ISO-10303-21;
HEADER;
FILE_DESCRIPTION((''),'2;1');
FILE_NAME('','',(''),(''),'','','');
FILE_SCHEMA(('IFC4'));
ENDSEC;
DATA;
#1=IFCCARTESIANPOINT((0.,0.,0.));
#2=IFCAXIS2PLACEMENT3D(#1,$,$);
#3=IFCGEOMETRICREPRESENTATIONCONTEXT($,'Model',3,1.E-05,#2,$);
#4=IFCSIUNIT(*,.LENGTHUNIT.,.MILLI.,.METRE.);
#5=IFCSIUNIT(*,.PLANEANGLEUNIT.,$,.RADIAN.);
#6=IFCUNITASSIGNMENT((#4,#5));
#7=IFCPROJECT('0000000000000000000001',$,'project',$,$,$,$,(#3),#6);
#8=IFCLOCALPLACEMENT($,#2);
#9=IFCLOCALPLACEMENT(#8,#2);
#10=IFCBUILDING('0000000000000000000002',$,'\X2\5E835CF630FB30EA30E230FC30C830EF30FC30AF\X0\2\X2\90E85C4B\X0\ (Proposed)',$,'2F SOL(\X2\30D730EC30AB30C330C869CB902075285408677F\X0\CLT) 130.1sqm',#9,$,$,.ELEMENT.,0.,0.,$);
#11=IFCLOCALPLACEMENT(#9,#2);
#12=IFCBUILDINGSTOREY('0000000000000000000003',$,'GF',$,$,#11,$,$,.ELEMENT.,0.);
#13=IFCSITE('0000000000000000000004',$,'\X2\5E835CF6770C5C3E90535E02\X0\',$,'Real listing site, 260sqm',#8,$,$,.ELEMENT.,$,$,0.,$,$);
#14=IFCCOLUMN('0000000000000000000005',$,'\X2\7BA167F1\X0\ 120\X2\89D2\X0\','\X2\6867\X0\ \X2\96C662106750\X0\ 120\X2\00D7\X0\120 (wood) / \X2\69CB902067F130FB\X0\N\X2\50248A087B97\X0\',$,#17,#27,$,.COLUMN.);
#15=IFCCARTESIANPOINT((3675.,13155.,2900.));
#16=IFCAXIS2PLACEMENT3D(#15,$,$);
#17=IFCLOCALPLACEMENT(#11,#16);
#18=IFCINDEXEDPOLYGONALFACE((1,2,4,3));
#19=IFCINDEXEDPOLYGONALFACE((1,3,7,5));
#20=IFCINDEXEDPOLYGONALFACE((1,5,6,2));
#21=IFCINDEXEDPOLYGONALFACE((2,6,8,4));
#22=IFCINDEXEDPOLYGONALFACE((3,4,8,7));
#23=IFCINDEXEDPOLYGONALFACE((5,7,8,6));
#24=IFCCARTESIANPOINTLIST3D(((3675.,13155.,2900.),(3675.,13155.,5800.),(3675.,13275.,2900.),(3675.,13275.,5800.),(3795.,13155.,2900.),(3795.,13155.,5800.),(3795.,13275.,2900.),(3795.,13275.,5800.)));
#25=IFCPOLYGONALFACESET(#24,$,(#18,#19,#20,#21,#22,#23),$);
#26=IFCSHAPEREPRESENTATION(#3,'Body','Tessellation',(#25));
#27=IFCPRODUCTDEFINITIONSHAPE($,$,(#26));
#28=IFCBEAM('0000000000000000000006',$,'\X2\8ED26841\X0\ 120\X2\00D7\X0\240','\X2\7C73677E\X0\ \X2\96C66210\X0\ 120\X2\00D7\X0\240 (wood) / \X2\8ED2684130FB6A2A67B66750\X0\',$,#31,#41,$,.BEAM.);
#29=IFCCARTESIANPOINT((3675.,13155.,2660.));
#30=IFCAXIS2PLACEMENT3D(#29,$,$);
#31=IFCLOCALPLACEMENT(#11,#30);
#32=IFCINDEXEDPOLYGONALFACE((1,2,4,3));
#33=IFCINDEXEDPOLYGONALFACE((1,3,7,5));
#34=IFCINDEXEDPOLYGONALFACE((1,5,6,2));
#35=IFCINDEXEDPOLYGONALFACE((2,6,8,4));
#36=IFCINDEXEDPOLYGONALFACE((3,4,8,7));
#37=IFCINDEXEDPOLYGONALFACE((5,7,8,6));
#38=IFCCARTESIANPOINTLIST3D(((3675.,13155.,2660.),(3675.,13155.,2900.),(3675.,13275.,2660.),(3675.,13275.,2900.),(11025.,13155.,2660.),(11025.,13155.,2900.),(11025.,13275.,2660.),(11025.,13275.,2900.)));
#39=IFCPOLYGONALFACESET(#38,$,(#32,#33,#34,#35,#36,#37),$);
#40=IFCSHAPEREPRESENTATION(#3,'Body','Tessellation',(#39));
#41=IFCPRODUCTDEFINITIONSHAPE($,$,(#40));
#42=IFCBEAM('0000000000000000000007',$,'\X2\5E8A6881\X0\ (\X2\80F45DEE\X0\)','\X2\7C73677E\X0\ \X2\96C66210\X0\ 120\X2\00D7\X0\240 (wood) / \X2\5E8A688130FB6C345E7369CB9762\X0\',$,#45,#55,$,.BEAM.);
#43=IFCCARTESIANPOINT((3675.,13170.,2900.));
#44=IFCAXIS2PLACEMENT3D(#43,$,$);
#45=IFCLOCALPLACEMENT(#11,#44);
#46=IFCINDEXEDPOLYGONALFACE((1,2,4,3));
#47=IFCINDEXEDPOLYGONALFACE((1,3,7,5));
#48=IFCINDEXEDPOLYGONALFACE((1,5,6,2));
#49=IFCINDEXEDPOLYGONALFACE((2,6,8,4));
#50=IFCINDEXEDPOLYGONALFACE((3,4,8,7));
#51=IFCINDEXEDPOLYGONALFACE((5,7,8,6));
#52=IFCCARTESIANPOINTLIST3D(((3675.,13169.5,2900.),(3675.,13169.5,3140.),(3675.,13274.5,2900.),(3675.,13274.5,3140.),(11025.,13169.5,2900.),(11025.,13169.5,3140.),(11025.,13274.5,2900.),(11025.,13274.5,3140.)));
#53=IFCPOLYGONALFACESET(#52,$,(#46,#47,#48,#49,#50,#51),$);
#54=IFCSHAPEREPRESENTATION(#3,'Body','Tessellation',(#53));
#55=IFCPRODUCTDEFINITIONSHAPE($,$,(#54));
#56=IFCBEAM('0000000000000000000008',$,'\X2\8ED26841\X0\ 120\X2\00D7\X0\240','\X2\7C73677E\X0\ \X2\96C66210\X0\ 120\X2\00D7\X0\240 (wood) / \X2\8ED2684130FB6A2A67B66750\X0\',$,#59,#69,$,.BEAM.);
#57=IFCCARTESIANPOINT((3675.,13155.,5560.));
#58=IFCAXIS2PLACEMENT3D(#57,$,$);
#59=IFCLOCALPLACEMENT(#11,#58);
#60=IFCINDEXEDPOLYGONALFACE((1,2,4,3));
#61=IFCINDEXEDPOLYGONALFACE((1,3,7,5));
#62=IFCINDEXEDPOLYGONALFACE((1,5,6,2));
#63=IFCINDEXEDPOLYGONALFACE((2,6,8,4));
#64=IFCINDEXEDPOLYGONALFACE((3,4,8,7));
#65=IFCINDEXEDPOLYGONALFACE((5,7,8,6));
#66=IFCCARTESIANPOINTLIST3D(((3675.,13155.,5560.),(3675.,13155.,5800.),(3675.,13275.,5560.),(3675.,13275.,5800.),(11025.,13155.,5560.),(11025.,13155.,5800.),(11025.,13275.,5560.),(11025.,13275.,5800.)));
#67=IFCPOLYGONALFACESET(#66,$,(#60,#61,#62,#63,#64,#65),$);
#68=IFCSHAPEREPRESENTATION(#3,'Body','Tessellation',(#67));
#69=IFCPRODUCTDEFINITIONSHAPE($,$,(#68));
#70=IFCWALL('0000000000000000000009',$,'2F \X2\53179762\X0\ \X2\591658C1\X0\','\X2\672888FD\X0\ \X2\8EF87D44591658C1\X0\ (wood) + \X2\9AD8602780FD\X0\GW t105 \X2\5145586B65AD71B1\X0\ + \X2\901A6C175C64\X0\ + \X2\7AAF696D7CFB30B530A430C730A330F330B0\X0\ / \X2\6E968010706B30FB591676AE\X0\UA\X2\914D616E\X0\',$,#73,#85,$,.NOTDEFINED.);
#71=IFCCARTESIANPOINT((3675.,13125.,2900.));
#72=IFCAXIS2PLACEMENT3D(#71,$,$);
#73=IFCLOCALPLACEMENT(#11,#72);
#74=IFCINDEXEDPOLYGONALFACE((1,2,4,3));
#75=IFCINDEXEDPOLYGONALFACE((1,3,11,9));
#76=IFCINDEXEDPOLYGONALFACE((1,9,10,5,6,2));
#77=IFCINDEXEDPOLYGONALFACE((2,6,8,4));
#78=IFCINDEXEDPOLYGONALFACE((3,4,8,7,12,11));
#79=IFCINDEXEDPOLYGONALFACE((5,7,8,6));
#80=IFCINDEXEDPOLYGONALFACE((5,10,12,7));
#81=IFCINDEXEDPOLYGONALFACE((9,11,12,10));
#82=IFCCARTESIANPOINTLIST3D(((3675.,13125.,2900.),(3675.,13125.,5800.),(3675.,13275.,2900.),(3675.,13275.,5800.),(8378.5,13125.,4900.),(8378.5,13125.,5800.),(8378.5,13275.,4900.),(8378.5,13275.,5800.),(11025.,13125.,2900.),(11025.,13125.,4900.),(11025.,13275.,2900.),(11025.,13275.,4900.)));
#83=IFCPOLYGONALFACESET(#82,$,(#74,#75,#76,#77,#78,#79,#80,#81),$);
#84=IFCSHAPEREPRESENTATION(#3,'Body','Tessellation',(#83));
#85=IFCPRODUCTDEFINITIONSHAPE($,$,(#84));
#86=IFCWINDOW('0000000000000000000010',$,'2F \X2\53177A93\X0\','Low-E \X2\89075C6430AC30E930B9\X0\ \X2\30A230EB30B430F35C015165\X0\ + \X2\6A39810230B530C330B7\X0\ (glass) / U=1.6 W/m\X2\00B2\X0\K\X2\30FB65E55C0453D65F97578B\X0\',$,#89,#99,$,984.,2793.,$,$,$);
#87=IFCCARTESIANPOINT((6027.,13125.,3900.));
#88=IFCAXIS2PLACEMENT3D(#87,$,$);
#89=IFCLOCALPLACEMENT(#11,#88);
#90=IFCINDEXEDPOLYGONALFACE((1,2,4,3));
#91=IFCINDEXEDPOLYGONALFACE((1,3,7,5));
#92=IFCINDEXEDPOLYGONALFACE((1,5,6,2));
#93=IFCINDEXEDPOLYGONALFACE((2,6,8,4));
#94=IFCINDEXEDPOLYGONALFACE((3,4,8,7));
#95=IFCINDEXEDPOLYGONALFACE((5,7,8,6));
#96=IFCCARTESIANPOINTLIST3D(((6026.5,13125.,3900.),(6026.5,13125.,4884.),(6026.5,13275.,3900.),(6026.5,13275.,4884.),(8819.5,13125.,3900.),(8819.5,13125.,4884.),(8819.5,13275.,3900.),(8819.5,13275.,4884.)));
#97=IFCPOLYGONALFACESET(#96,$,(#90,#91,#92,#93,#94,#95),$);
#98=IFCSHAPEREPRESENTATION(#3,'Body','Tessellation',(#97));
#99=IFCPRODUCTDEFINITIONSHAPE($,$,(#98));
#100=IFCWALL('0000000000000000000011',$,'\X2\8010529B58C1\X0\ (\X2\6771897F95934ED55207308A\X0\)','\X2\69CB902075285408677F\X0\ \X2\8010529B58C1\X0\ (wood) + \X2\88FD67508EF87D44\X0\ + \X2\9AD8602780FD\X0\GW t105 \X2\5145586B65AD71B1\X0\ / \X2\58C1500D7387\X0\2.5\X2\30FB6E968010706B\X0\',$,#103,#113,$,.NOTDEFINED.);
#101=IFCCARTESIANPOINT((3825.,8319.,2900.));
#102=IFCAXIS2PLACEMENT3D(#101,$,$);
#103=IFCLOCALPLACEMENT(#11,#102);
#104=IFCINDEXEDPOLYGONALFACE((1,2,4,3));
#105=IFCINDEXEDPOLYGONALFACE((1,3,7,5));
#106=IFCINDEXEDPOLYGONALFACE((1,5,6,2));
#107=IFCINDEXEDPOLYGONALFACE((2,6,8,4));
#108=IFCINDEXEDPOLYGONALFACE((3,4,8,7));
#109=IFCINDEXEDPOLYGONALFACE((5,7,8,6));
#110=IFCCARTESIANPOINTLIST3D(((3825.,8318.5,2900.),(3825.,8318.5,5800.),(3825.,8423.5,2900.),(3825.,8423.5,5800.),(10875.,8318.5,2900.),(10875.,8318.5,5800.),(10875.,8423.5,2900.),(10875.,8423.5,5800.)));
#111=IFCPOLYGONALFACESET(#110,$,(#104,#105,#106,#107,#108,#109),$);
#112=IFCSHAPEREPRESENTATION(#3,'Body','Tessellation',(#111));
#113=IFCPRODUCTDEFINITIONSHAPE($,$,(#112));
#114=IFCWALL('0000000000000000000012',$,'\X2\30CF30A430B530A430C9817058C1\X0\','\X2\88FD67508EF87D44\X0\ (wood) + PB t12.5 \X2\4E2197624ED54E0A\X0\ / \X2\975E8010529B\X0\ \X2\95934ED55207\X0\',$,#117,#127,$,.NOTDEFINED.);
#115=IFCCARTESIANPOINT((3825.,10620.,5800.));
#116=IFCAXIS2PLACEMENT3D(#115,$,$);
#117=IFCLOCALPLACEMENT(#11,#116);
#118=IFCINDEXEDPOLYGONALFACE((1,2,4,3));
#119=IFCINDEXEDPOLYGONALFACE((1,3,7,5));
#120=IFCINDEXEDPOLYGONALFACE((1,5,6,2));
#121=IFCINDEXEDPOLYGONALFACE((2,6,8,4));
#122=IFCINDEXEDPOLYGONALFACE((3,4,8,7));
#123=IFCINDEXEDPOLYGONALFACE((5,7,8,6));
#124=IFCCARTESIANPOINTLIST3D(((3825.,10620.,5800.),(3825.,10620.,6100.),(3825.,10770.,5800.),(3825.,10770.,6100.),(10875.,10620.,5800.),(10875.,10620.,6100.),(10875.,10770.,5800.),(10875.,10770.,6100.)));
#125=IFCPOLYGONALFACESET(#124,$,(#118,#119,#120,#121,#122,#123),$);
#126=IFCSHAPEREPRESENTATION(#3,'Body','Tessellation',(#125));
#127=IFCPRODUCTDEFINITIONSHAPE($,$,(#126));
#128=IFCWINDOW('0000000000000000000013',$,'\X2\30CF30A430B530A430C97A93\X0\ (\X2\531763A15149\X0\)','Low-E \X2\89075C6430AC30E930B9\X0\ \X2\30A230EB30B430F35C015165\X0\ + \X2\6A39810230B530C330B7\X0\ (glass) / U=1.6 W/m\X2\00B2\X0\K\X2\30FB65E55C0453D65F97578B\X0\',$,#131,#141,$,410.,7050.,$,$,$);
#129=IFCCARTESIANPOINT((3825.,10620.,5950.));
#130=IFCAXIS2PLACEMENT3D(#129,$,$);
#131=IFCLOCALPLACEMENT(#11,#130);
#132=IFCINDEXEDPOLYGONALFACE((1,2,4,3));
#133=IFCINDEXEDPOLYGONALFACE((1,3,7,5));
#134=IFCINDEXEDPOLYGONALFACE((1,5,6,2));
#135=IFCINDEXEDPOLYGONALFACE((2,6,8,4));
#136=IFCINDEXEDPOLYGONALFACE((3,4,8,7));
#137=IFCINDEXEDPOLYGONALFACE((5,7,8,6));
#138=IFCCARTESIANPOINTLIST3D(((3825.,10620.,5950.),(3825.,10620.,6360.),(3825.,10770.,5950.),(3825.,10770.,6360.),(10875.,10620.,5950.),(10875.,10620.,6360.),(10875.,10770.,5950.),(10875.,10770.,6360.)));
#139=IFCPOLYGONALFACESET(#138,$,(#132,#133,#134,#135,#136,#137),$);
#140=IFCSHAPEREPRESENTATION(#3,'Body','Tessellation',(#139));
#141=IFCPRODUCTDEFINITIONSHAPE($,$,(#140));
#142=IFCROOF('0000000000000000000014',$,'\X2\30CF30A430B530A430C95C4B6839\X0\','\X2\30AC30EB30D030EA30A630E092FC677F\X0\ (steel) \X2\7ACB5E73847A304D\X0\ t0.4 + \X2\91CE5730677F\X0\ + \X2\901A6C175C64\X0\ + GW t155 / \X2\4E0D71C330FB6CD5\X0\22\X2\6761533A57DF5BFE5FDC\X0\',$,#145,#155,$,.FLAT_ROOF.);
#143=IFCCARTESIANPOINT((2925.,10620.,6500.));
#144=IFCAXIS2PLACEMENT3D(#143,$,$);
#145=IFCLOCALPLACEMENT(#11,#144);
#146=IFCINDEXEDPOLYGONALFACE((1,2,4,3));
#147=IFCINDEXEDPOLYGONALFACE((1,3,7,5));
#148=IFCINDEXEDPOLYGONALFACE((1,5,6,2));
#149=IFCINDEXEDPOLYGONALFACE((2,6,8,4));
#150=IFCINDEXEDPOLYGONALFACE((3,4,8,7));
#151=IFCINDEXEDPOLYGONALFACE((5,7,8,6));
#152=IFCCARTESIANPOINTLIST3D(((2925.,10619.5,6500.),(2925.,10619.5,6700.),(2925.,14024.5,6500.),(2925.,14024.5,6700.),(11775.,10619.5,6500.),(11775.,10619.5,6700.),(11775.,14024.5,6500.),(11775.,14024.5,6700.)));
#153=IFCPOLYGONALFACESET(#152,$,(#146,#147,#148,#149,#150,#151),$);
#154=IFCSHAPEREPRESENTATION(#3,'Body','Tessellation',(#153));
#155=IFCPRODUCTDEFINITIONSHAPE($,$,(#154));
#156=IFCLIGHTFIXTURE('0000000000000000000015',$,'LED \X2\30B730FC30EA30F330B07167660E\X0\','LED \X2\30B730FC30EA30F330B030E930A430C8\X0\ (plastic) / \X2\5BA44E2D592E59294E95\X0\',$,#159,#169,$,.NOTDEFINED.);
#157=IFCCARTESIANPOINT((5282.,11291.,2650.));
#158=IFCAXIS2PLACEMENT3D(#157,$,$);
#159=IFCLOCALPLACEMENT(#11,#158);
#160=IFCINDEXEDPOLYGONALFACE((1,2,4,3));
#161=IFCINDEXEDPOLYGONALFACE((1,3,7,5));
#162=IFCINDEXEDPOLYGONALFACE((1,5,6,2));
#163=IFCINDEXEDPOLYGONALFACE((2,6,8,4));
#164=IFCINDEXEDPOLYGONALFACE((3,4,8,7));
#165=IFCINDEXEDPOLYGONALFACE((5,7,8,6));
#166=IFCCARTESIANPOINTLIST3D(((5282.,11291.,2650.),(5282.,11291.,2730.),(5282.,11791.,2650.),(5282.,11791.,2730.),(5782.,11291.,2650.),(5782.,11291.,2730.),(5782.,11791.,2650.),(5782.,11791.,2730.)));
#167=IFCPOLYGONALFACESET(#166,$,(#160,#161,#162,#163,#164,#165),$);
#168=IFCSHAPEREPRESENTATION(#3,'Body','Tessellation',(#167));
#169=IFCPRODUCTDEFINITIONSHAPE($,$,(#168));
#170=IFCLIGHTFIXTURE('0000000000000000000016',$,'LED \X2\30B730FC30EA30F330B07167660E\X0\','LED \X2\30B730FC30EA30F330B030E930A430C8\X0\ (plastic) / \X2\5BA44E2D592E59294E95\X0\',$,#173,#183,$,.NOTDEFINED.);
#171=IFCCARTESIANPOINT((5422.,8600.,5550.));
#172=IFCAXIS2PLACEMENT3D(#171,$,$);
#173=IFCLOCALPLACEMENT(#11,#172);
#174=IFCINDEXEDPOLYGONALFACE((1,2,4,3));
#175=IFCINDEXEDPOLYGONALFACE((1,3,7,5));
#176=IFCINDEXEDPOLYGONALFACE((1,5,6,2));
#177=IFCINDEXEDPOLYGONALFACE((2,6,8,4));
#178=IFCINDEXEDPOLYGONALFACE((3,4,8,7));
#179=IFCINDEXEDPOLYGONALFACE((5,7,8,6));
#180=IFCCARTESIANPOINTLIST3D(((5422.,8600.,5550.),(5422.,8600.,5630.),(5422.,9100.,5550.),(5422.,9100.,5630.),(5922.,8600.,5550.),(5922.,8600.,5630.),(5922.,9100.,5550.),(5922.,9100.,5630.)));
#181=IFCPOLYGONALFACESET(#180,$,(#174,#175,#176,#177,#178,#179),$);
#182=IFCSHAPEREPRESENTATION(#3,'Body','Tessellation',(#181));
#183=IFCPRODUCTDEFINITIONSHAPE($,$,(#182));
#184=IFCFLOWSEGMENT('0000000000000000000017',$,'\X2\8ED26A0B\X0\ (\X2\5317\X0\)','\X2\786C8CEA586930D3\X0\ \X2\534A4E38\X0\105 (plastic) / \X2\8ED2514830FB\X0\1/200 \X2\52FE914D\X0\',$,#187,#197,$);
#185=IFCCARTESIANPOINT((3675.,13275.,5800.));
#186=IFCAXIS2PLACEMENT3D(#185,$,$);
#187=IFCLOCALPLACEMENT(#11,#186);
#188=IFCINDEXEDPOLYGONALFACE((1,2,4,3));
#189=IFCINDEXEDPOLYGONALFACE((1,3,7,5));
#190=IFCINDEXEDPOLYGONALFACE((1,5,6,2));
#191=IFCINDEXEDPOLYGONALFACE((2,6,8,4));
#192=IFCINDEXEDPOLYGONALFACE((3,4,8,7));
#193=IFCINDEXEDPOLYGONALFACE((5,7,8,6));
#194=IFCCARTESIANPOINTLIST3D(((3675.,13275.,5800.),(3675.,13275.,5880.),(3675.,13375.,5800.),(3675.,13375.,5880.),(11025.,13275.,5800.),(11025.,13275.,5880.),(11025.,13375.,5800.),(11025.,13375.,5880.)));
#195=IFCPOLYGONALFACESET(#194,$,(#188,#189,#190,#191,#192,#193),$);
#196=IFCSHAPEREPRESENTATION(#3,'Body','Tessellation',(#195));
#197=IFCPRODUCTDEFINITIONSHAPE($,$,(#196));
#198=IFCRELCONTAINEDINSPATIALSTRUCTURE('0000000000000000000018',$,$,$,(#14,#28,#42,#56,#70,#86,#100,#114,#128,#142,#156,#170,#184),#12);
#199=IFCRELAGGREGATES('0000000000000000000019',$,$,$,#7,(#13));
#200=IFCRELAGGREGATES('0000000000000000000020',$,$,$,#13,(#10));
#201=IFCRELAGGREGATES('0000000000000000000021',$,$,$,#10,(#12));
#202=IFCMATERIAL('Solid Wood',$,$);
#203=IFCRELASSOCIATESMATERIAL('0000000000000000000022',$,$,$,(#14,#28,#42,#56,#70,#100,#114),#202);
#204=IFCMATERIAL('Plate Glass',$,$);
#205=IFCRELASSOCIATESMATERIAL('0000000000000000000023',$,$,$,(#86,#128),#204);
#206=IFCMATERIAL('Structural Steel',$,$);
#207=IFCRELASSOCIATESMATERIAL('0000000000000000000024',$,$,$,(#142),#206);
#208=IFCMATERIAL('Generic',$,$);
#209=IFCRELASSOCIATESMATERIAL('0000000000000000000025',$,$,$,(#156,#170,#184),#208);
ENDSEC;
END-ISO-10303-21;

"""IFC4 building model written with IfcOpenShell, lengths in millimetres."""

from ifc_helpers import new_model, si_unit, frame, frame_2d, origin, place, context, project, spatial, rectangle, extrude, material, element, fill, save


model = new_model("IFC4")

# Units and contexts
model_context = context("Model", 3, precision=1e-05, world=origin())
ifc_project = project(units=[si_unit("LENGTHUNIT", "METRE", prefix="MILLI"), si_unit("PLANEANGLEUNIT", "RADIAN")], contexts=[model_context])

# Site, building, storey
site_placement = place(None, origin())
site = spatial("IfcSite", under=ifc_project, at=site_placement, Name="広島県尾道市", ObjectType="Real listing site, 260sqm", CompositionType="ELEMENT", RefElevation=0.0)
building_placement = place(site_placement, origin())
building = spatial("IfcBuilding", under=site, at=building_placement, Name="広島・リモートワーク2部屋 (Proposed)", ObjectType="2F SOL(プレカット構造用合板CLT) 130.1sqm", CompositionType="ELEMENT", ElevationOfRefHeight=0.0, ElevationOfTerrain=0.0)
storey_placement = place(building_placement, origin())
storey = spatial("IfcBuildingStorey", under=building, at=storey_placement, Name="GF", CompositionType="ELEMENT", Elevation=0.0)

# Column
ifc_material_1 = material(Name="Solid Wood")
column_1_placement = place(storey_placement, frame((3675.0, 13155.0, 2900.0)))
element("IfcColumn", 1, at=column_1_placement, inside=storey, material=ifc_material_1, Name="管柱 120角", Description="桧 集成材 120×120 (wood) / 構造柱・N値計算", PredefinedType="COLUMN", context=model_context, shape_type="SweptSolid", body=[
    extrude(rectangle(XDim=120.0, YDim=120.0, at=frame_2d((60.0, 60.0))), frame((3675.0, 13155.0, 2900.0)), (0.0, 0.0, 1.0), 2900.0),
])

# Beams
beam_1_placement = place(storey_placement, frame((3675.0, 13155.0, 2660.0)))
element("IfcBeam", 2, at=beam_1_placement, inside=storey, material=ifc_material_1, Name="軒桁 120×240", Description="米松 集成 120×240 (wood) / 軒桁・横架材", PredefinedType="BEAM", context=model_context, shape_type="SweptSolid", body=[
    extrude(rectangle(XDim=7350.0, YDim=120.0, at=frame_2d((3675.0, 60.0))), frame((3675.0, 13155.0, 2660.0)), (0.0, 0.0, 1.0), 240.0),
])
beam_2_placement = place(storey_placement, frame((3675.0, 13170.0, 2900.0)))
element("IfcBeam", 3, at=beam_2_placement, inside=storey, material=ifc_material_1, Name="床梁 (胴差)", Description="米松 集成 120×240 (wood) / 床梁・水平構面", PredefinedType="BEAM", context=model_context, shape_type="SweptSolid", body=[
    extrude(rectangle(XDim=7350.0, YDim=105.0, at=frame_2d((3675.0, 52.0))), frame((3675.0, 13170.0, 2900.0)), (0.0, 0.0, 1.0), 240.0),
])
beam_3_placement = place(storey_placement, frame((3675.0, 13155.0, 5560.0)))
element("IfcBeam", 4, at=beam_3_placement, inside=storey, material=ifc_material_1, Name="軒桁 120×240", Description="米松 集成 120×240 (wood) / 軒桁・横架材", PredefinedType="BEAM", context=model_context, shape_type="SweptSolid", body=[
    extrude(rectangle(XDim=7350.0, YDim=120.0, at=frame_2d((3675.0, 60.0))), frame((3675.0, 13155.0, 5560.0)), (0.0, 0.0, 1.0), 240.0),
])

# Wall, opening, window
wall_1_placement = place(storey_placement, frame((3675.0, 13125.0, 2900.0)))
wall_1 = element("IfcWall", 5, at=wall_1_placement, inside=storey, material=ifc_material_1, Name="2F 北面 外壁", Description="木製 軸組外壁 (wood) + 高性能GW t105 充填断熱 + 通気層 + 窯業系サイディング / 準耐火・外皮UA配慮", PredefinedType="NOTDEFINED", context=model_context, shape_type="SweptSolid", body=[
    extrude(rectangle(XDim=7350.0, YDim=150.0, at=frame_2d((3675.0, 75.0))), frame((3675.0, 13125.0, 2900.0)), (0.0, 0.0, 1.0), 2900.0),
])
opening_1_placement = place(storey_placement, frame((6027.0, 13125.0, 3900.0)))
opening_1 = element("IfcOpeningElement", 6, at=opening_1_placement, cuts=wall_1, PredefinedType="NOTDEFINED", context=model_context, shape_type="SweptSolid", body=[
    extrude(rectangle(XDim=2793.0, YDim=150.0, at=frame_2d((1396.0, 75.0))), frame((6027.0, 13125.0, 3900.0)), (0.0, 0.0, 1.0), 984.0),
])
ifc_material_2 = material(Name="Plate Glass")
window_1_placement = place(storey_placement, frame((6027.0, 13125.0, 3900.0)))
window_1 = element("IfcWindow", 7, at=window_1_placement, inside=storey, material=ifc_material_2, Name="2F 北窓", Description="Low-E 複層ガラス アルゴン封入 + 樹脂サッシ (glass) / U=1.6 W/m²K・日射取得型", OverallHeight=984.0, OverallWidth=2793.0, context=model_context, shape_type="SweptSolid", body=[
    extrude(rectangle(XDim=2793.0, YDim=150.0, at=frame_2d((1396.0, 75.0))), frame((6027.0, 13125.0, 3900.0)), (0.0, 0.0, 1.0), 984.0),
])
fill(opening_1, window_1)

# Wall
wall_2_placement = place(storey_placement, frame((3825.0, 8319.0, 2900.0)))
element("IfcWall", 8, at=wall_2_placement, inside=storey, material=ifc_material_1, Name="耐力壁 (東西間仕切り)", Description="構造用合板 耐力壁 (wood) + 製材軸組 + 高性能GW t105 充填断熱 / 壁倍率2.5・準耐火", PredefinedType="NOTDEFINED", context=model_context, shape_type="SweptSolid", body=[
    extrude(rectangle(XDim=7050.0, YDim=105.0, at=frame_2d((3525.0, 52.0))), frame((3825.0, 8319.0, 2900.0)), (0.0, 0.0, 1.0), 2900.0),
])

# Wall, opening, window
wall_3_placement = place(storey_placement, frame((3825.0, 10620.0, 5800.0)))
wall_3 = element("IfcWall", 9, at=wall_3_placement, inside=storey, material=ifc_material_1, Name="ハイサイド腰壁", Description="製材軸組 (wood) + PB t12.5 両面仕上 / 非耐力 間仕切", PredefinedType="NOTDEFINED", context=model_context, shape_type="SweptSolid", body=[
    extrude(rectangle(XDim=7050.0, YDim=150.0, at=frame_2d((3525.0, 75.0))), frame((3825.0, 10620.0, 5800.0)), (0.0, 0.0, 1.0), 700.0),
])
opening_2_placement = place(storey_placement, frame((3825.0, 10620.0, 5950.0)))
opening_2 = element("IfcOpeningElement", 10, at=opening_2_placement, cuts=wall_3, PredefinedType="NOTDEFINED", context=model_context, shape_type="SweptSolid", body=[
    extrude(rectangle(XDim=7050.0, YDim=150.0, at=frame_2d((3525.0, 75.0))), frame((3825.0, 10620.0, 5950.0)), (0.0, 0.0, 1.0), 410.0),
])
window_2_placement = place(storey_placement, frame((3825.0, 10620.0, 5950.0)))
window_2 = element("IfcWindow", 11, at=window_2_placement, inside=storey, material=ifc_material_2, Name="ハイサイド窓 (北採光)", Description="Low-E 複層ガラス アルゴン封入 + 樹脂サッシ (glass) / U=1.6 W/m²K・日射取得型", OverallHeight=410.0, OverallWidth=7050.0, context=model_context, shape_type="SweptSolid", body=[
    extrude(rectangle(XDim=7050.0, YDim=150.0, at=frame_2d((3525.0, 75.0))), frame((3825.0, 10620.0, 5950.0)), (0.0, 0.0, 1.0), 410.0),
])
fill(opening_2, window_2)

# Roof
ifc_material_3 = material(Name="Structural Steel")
roof_placement = place(storey_placement, frame((2925.0, 10620.0, 6500.0)))
element("IfcRoof", 12, at=roof_placement, inside=storey, material=ifc_material_3, Name="ハイサイド屋根", Description="ガルバリウム鋼板 (steel) 立平葺き t0.4 + 野地板 + 通気層 + GW t155 / 不燃・法22条区域対応", PredefinedType="FLAT_ROOF", context=model_context, shape_type="SweptSolid", body=[
    extrude(rectangle(XDim=8850.0, YDim=3405.0, at=frame_2d((4425.0, 1702.0))), frame((2925.0, 10620.0, 6500.0)), (0.0, 0.0, 1.0), 200.0),
])

# Light fixtures
ifc_material_4 = material(Name="Generic")
light_fixture_1_placement = place(storey_placement, frame((5282.0, 11291.0, 2650.0)))
element("IfcLightFixture", 13, at=light_fixture_1_placement, inside=storey, material=ifc_material_4, Name="LED シーリング照明", Description="LED シーリングライト (plastic) / 室中央天井", PredefinedType="NOTDEFINED", context=model_context, shape_type="SweptSolid", body=[
    extrude(rectangle(XDim=500.0, YDim=500.0, at=frame_2d((250.0, 250.0))), frame((5282.0, 11291.0, 2650.0)), (0.0, 0.0, 1.0), 80.0),
])
light_fixture_2_placement = place(storey_placement, frame((5422.0, 8600.0, 5550.0)))
element("IfcLightFixture", 14, at=light_fixture_2_placement, inside=storey, material=ifc_material_4, Name="LED シーリング照明", Description="LED シーリングライト (plastic) / 室中央天井", PredefinedType="NOTDEFINED", context=model_context, shape_type="SweptSolid", body=[
    extrude(rectangle(XDim=500.0, YDim=500.0, at=frame_2d((250.0, 250.0))), frame((5422.0, 8600.0, 5550.0)), (0.0, 0.0, 1.0), 80.0),
])

# Flow segment
flow_segment_placement = place(storey_placement, frame((3675.0, 13275.0, 5800.0)))
element("IfcFlowSegment", 15, at=flow_segment_placement, inside=storey, material=ifc_material_4, Name="軒樋 (北)", Description="硬質塩ビ 半丸105 (plastic) / 軒先・1/200 勾配", context=model_context, shape_type="SweptSolid", body=[
    extrude(rectangle(XDim=7350.0, YDim=100.0, at=frame_2d((3675.0, 50.0))), frame((3675.0, 13275.0, 5800.0)), (0.0, 0.0, 1.0), 80.0),
])

save(model, "model.ifc")
